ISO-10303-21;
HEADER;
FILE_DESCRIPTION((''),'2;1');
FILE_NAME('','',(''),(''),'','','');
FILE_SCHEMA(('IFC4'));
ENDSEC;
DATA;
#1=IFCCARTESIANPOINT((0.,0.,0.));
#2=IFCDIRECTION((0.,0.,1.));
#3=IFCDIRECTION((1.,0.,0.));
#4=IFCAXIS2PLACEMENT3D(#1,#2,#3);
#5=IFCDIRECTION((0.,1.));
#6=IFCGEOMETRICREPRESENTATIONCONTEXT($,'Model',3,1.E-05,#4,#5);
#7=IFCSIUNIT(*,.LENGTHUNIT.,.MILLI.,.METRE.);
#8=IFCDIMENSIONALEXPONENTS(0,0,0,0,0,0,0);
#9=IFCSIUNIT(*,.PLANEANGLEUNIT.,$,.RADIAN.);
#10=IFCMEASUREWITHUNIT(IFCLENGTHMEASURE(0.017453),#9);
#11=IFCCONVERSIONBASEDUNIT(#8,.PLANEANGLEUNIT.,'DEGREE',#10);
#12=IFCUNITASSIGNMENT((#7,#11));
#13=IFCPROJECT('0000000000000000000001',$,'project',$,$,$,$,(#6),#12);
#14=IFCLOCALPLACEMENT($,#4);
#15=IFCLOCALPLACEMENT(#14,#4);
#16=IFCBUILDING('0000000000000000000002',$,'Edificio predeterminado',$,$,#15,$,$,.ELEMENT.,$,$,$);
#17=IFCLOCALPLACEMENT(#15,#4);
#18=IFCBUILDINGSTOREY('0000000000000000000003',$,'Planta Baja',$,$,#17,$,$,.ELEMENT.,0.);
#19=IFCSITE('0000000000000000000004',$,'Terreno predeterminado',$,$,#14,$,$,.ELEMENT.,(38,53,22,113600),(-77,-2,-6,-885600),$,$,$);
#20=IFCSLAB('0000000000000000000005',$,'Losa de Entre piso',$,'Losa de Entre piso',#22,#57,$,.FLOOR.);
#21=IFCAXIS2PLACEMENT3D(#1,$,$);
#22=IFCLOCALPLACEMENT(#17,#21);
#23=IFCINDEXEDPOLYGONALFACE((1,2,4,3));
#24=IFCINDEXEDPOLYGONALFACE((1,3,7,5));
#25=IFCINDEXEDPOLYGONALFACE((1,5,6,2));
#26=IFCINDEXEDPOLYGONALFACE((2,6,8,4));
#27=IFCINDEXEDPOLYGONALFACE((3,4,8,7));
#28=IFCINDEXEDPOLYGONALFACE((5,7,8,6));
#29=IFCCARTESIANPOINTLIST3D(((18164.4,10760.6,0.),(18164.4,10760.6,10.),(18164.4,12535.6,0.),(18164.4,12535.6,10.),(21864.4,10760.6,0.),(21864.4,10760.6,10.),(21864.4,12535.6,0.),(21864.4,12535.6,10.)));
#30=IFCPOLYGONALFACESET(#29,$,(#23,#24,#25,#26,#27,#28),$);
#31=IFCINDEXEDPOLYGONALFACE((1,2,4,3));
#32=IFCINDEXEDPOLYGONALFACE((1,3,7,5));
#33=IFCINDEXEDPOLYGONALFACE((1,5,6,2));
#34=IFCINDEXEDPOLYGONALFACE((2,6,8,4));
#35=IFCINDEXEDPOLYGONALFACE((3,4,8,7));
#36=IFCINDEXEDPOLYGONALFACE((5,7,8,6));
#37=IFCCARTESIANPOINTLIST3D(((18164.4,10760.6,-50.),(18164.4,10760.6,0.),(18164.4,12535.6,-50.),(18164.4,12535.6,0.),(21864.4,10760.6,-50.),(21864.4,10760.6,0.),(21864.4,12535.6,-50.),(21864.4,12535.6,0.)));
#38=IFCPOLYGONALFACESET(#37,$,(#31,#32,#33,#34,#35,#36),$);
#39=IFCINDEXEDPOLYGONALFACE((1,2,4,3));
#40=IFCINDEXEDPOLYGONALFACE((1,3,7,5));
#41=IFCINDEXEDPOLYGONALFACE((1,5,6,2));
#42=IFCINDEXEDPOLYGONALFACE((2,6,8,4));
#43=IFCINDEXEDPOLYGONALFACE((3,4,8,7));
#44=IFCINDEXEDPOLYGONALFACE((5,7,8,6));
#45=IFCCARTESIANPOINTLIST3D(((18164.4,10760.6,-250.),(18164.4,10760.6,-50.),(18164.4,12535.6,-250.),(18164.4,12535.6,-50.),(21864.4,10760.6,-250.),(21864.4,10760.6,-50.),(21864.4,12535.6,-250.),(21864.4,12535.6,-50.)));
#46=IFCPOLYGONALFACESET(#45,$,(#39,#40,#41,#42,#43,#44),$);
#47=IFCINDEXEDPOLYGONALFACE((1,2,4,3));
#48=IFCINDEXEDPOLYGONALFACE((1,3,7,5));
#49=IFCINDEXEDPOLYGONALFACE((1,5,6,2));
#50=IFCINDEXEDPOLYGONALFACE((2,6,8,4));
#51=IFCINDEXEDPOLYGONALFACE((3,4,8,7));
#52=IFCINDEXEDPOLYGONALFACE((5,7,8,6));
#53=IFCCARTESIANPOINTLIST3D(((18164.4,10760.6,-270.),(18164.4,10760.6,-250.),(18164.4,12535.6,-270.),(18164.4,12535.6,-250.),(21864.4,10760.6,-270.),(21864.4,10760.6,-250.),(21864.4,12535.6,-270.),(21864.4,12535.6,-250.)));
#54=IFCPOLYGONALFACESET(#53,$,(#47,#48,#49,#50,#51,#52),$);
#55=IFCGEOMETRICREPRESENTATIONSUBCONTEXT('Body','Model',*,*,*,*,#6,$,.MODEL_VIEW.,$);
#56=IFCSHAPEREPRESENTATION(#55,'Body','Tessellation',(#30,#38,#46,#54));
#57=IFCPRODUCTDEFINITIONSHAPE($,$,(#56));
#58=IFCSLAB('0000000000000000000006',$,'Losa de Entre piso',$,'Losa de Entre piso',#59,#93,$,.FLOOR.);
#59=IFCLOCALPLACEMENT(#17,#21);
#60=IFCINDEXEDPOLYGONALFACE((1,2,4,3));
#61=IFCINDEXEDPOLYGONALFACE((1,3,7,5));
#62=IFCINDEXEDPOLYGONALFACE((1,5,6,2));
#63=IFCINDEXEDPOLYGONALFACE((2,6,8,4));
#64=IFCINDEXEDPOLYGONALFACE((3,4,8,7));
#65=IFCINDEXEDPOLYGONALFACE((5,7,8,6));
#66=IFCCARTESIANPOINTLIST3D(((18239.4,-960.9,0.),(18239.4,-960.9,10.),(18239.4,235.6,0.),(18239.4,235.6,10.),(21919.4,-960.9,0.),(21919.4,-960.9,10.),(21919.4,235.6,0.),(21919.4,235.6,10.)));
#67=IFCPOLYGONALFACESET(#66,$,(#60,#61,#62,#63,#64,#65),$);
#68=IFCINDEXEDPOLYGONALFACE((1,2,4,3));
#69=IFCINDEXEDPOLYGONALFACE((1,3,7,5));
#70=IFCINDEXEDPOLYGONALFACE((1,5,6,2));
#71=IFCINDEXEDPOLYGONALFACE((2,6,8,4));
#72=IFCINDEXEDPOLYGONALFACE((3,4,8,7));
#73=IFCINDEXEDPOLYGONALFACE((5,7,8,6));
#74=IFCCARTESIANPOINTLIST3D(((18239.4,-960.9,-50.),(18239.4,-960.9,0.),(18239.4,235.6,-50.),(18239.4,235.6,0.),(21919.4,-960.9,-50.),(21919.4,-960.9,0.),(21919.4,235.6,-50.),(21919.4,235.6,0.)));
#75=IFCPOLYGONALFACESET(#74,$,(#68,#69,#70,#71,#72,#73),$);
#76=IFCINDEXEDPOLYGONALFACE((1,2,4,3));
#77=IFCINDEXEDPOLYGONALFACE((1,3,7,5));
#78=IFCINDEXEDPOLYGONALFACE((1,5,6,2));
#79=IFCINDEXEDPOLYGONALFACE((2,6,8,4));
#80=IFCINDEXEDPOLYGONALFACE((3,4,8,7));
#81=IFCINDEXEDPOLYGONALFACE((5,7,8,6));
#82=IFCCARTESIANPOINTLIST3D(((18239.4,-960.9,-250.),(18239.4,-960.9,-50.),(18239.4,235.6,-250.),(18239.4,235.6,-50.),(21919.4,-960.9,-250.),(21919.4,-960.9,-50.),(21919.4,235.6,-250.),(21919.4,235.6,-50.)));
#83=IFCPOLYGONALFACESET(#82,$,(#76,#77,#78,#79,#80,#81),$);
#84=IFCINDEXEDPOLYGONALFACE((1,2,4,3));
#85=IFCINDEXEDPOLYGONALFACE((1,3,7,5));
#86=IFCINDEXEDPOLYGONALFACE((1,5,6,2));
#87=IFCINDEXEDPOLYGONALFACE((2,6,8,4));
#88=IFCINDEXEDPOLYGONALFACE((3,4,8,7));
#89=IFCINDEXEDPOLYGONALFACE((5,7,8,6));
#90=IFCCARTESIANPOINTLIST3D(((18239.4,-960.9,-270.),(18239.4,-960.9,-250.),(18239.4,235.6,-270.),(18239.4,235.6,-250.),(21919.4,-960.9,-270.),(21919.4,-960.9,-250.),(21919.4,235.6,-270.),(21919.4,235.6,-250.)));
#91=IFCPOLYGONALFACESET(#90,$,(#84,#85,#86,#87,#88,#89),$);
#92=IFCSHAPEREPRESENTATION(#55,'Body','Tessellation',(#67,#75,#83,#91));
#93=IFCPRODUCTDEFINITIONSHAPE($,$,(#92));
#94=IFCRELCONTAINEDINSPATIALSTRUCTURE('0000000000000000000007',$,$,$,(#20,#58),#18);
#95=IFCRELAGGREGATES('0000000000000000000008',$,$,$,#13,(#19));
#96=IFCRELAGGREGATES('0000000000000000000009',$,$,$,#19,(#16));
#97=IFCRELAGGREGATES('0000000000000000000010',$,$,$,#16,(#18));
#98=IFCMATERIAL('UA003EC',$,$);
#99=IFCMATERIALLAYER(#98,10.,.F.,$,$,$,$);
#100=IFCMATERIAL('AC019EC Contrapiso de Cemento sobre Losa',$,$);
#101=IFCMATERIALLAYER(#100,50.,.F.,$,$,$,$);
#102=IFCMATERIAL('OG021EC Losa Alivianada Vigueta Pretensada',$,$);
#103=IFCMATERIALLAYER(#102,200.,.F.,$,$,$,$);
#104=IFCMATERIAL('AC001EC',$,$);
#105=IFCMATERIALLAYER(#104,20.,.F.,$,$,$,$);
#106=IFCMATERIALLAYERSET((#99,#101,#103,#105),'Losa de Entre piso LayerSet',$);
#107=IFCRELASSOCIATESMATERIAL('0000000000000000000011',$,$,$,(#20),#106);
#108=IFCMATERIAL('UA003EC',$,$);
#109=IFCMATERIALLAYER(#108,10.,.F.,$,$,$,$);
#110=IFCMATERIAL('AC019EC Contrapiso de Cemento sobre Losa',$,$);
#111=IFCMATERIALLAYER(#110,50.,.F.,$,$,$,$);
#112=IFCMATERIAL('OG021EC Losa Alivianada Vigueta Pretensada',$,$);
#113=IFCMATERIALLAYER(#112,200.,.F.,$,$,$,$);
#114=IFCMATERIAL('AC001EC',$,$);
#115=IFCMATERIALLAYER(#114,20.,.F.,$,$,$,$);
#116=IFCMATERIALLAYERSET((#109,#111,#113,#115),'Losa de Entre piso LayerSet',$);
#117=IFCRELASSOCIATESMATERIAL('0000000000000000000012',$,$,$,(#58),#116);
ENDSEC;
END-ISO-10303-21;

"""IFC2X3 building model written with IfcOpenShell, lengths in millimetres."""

from ifc_helpers import new_model, entity, si_unit, converted_unit, direction, frame, origin_with_axes, place, context, subcontext, project, spatial, polyline, outline, extrude, material, layer, layer_set, layer_usage, element, save


model = new_model("IFC2X3")

# Units and contexts
model_context = context("Model", 3, precision=1e-05, world=origin_with_axes(), true_north=direction((0.0, 1.0)))
body_context = subcontext(model_context, "Body", "Model", "MODEL_VIEW")
ifc_project = project(units=[si_unit("LENGTHUNIT", "METRE", prefix="MILLI"), converted_unit("PLANEANGLEUNIT", "DEGREE", entity("IfcLengthMeasure", 0.017453), si_unit("PLANEANGLEUNIT", "RADIAN"), dimensions=[0, 0, 0, 0, 0, 0, 0])], contexts=[model_context])

# Site, building, storey
site_placement = place(None, origin_with_axes())
site = spatial("IfcSite", under=ifc_project, at=site_placement, Name="Terreno predeterminado", CompositionType="ELEMENT", RefLatitude=(38, 53, 22, 113600), RefLongitude=(-77, -2, -6, -885600))
building_placement = place(site_placement, origin_with_axes())
building = spatial("IfcBuilding", under=site, at=building_placement, Name="Edificio predeterminado", CompositionType="ELEMENT")
storey_placement = place(building_placement, origin_with_axes())
storey = spatial("IfcBuildingStorey", under=building, at=storey_placement, Name="Planta Baja", CompositionType="ELEMENT", Elevation=0.0)

# Slabs
ifc_material_1 = material(Name="UA003EC")
ifc_layer_1 = layer(ifc_material_1, 10.0, ventilated=False)
ifc_material_2 = material(Name="AC019EC Contrapiso de Cemento sobre Losa")
ifc_layer_2 = layer(ifc_material_2, 50.0, ventilated=False)
ifc_material_3 = material(Name="OG021EC Losa Alivianada Vigueta Pretensada")
ifc_layer_3 = layer(ifc_material_3, 200.0, ventilated=False)
ifc_material_4 = material(Name="AC001EC")
ifc_layer_4 = layer(ifc_material_4, 20.0, ventilated=False)
ifc_layer_set_1 = layer_set([ifc_layer_1, ifc_layer_2, ifc_layer_3, ifc_layer_4], Name="Losa de Entre piso LayerSet")
ifc_layer_usage_1 = layer_usage(ifc_layer_set_1, "AXIS3", "POSITIVE", 0.0)
slab_1_placement = place(storey_placement, origin_with_axes())
element("IfcSlab", 1, at=slab_1_placement, inside=storey, material=ifc_layer_usage_1, Name="Losa de Entre piso", ObjectType="Losa de Entre piso", PredefinedType="FLOOR", context=body_context, shape_type="SweptSolid", body=[
    extrude(outline(polyline([(0.0, 0.0), (1775.0, 0.0), (1775.0, 3700.0), (0.0, 3700.0), (0.0, 0.0)])), frame((21864.4, 12535.6, 0.0), z_axis=(0.0, 0.0, -1.0), x_axis=(0.0, -1.0, 0.0)), (0.0, 0.0, -1.0), 10.0),
    extrude(outline(polyline([(0.0, 0.0), (1775.0, 0.0), (1775.0, 3700.0), (0.0, 3700.0), (0.0, 0.0)])), frame((21864.4, 12535.6, -50.0), z_axis=(0.0, 0.0, -1.0), x_axis=(0.0, -1.0, 0.0)), (0.0, 0.0, -1.0), 50.0),
    extrude(outline(polyline([(0.0, 0.0), (1775.0, 0.0), (1775.0, 3700.0), (0.0, 3700.0), (0.0, 0.0)])), frame((21864.4, 12535.6, -250.0), z_axis=(0.0, 0.0, -1.0), x_axis=(0.0, -1.0, 0.0)), (0.0, 0.0, -1.0), 200.0),
    extrude(outline(polyline([(0.0, 0.0), (1775.0, 0.0), (1775.0, 3700.0), (0.0, 3700.0), (0.0, 0.0)])), frame((21864.4, 12535.6, -270.0), z_axis=(0.0, 0.0, -1.0), x_axis=(0.0, -1.0, 0.0)), (0.0, 0.0, -1.0), 20.0),
])
ifc_material_5 = material(Name="UA003EC")
ifc_layer_5 = layer(ifc_material_5, 10.0, ventilated=False)
ifc_material_6 = material(Name="AC019EC Contrapiso de Cemento sobre Losa")
ifc_layer_6 = layer(ifc_material_6, 50.0, ventilated=False)
ifc_material_7 = material(Name="OG021EC Losa Alivianada Vigueta Pretensada")
ifc_layer_7 = layer(ifc_material_7, 200.0, ventilated=False)
ifc_material_8 = material(Name="AC001EC")
ifc_layer_8 = layer(ifc_material_8, 20.0, ventilated=False)
ifc_layer_set_2 = layer_set([ifc_layer_5, ifc_layer_6, ifc_layer_7, ifc_layer_8], Name="Losa de Entre piso LayerSet")
ifc_layer_usage_2 = layer_usage(ifc_layer_set_2, "AXIS3", "POSITIVE", 0.0)
slab_2_placement = place(storey_placement, origin_with_axes())
element("IfcSlab", 2, at=slab_2_placement, inside=storey, material=ifc_layer_usage_2, Name="Losa de Entre piso", ObjectType="Losa de Entre piso", PredefinedType="FLOOR", context=body_context, shape_type="SweptSolid", body=[
    extrude(outline(polyline([(0.0, 0.0), (1196.6, 0.0), (1196.6, 3680.0), (0.0, 3680.0), (0.0, 0.0)])), frame((21919.4, 235.6, 0.0), z_axis=(0.0, 0.0, -1.0), x_axis=(0.0, -1.0, 0.0)), (0.0, 0.0, -1.0), 10.0),
    extrude(outline(polyline([(0.0, 0.0), (1196.6, 0.0), (1196.6, 3680.0), (0.0, 3680.0), (0.0, 0.0)])), frame((21919.4, 235.6, -50.0), z_axis=(0.0, 0.0, -1.0), x_axis=(0.0, -1.0, 0.0)), (0.0, 0.0, -1.0), 50.0),
    extrude(outline(polyline([(0.0, 0.0), (1196.6, 0.0), (1196.6, 3680.0), (0.0, 3680.0), (0.0, 0.0)])), frame((21919.4, 235.6, -250.0), z_axis=(0.0, 0.0, -1.0), x_axis=(0.0, -1.0, 0.0)), (0.0, 0.0, -1.0), 200.0),
    extrude(outline(polyline([(0.0, 0.0), (1196.6, 0.0), (1196.6, 3680.0), (0.0, 3680.0), (0.0, 0.0)])), frame((21919.4, 235.6, -270.0), z_axis=(0.0, 0.0, -1.0), x_axis=(0.0, -1.0, 0.0)), (0.0, 0.0, -1.0), 20.0),
])

save(model, "model.ifc")
